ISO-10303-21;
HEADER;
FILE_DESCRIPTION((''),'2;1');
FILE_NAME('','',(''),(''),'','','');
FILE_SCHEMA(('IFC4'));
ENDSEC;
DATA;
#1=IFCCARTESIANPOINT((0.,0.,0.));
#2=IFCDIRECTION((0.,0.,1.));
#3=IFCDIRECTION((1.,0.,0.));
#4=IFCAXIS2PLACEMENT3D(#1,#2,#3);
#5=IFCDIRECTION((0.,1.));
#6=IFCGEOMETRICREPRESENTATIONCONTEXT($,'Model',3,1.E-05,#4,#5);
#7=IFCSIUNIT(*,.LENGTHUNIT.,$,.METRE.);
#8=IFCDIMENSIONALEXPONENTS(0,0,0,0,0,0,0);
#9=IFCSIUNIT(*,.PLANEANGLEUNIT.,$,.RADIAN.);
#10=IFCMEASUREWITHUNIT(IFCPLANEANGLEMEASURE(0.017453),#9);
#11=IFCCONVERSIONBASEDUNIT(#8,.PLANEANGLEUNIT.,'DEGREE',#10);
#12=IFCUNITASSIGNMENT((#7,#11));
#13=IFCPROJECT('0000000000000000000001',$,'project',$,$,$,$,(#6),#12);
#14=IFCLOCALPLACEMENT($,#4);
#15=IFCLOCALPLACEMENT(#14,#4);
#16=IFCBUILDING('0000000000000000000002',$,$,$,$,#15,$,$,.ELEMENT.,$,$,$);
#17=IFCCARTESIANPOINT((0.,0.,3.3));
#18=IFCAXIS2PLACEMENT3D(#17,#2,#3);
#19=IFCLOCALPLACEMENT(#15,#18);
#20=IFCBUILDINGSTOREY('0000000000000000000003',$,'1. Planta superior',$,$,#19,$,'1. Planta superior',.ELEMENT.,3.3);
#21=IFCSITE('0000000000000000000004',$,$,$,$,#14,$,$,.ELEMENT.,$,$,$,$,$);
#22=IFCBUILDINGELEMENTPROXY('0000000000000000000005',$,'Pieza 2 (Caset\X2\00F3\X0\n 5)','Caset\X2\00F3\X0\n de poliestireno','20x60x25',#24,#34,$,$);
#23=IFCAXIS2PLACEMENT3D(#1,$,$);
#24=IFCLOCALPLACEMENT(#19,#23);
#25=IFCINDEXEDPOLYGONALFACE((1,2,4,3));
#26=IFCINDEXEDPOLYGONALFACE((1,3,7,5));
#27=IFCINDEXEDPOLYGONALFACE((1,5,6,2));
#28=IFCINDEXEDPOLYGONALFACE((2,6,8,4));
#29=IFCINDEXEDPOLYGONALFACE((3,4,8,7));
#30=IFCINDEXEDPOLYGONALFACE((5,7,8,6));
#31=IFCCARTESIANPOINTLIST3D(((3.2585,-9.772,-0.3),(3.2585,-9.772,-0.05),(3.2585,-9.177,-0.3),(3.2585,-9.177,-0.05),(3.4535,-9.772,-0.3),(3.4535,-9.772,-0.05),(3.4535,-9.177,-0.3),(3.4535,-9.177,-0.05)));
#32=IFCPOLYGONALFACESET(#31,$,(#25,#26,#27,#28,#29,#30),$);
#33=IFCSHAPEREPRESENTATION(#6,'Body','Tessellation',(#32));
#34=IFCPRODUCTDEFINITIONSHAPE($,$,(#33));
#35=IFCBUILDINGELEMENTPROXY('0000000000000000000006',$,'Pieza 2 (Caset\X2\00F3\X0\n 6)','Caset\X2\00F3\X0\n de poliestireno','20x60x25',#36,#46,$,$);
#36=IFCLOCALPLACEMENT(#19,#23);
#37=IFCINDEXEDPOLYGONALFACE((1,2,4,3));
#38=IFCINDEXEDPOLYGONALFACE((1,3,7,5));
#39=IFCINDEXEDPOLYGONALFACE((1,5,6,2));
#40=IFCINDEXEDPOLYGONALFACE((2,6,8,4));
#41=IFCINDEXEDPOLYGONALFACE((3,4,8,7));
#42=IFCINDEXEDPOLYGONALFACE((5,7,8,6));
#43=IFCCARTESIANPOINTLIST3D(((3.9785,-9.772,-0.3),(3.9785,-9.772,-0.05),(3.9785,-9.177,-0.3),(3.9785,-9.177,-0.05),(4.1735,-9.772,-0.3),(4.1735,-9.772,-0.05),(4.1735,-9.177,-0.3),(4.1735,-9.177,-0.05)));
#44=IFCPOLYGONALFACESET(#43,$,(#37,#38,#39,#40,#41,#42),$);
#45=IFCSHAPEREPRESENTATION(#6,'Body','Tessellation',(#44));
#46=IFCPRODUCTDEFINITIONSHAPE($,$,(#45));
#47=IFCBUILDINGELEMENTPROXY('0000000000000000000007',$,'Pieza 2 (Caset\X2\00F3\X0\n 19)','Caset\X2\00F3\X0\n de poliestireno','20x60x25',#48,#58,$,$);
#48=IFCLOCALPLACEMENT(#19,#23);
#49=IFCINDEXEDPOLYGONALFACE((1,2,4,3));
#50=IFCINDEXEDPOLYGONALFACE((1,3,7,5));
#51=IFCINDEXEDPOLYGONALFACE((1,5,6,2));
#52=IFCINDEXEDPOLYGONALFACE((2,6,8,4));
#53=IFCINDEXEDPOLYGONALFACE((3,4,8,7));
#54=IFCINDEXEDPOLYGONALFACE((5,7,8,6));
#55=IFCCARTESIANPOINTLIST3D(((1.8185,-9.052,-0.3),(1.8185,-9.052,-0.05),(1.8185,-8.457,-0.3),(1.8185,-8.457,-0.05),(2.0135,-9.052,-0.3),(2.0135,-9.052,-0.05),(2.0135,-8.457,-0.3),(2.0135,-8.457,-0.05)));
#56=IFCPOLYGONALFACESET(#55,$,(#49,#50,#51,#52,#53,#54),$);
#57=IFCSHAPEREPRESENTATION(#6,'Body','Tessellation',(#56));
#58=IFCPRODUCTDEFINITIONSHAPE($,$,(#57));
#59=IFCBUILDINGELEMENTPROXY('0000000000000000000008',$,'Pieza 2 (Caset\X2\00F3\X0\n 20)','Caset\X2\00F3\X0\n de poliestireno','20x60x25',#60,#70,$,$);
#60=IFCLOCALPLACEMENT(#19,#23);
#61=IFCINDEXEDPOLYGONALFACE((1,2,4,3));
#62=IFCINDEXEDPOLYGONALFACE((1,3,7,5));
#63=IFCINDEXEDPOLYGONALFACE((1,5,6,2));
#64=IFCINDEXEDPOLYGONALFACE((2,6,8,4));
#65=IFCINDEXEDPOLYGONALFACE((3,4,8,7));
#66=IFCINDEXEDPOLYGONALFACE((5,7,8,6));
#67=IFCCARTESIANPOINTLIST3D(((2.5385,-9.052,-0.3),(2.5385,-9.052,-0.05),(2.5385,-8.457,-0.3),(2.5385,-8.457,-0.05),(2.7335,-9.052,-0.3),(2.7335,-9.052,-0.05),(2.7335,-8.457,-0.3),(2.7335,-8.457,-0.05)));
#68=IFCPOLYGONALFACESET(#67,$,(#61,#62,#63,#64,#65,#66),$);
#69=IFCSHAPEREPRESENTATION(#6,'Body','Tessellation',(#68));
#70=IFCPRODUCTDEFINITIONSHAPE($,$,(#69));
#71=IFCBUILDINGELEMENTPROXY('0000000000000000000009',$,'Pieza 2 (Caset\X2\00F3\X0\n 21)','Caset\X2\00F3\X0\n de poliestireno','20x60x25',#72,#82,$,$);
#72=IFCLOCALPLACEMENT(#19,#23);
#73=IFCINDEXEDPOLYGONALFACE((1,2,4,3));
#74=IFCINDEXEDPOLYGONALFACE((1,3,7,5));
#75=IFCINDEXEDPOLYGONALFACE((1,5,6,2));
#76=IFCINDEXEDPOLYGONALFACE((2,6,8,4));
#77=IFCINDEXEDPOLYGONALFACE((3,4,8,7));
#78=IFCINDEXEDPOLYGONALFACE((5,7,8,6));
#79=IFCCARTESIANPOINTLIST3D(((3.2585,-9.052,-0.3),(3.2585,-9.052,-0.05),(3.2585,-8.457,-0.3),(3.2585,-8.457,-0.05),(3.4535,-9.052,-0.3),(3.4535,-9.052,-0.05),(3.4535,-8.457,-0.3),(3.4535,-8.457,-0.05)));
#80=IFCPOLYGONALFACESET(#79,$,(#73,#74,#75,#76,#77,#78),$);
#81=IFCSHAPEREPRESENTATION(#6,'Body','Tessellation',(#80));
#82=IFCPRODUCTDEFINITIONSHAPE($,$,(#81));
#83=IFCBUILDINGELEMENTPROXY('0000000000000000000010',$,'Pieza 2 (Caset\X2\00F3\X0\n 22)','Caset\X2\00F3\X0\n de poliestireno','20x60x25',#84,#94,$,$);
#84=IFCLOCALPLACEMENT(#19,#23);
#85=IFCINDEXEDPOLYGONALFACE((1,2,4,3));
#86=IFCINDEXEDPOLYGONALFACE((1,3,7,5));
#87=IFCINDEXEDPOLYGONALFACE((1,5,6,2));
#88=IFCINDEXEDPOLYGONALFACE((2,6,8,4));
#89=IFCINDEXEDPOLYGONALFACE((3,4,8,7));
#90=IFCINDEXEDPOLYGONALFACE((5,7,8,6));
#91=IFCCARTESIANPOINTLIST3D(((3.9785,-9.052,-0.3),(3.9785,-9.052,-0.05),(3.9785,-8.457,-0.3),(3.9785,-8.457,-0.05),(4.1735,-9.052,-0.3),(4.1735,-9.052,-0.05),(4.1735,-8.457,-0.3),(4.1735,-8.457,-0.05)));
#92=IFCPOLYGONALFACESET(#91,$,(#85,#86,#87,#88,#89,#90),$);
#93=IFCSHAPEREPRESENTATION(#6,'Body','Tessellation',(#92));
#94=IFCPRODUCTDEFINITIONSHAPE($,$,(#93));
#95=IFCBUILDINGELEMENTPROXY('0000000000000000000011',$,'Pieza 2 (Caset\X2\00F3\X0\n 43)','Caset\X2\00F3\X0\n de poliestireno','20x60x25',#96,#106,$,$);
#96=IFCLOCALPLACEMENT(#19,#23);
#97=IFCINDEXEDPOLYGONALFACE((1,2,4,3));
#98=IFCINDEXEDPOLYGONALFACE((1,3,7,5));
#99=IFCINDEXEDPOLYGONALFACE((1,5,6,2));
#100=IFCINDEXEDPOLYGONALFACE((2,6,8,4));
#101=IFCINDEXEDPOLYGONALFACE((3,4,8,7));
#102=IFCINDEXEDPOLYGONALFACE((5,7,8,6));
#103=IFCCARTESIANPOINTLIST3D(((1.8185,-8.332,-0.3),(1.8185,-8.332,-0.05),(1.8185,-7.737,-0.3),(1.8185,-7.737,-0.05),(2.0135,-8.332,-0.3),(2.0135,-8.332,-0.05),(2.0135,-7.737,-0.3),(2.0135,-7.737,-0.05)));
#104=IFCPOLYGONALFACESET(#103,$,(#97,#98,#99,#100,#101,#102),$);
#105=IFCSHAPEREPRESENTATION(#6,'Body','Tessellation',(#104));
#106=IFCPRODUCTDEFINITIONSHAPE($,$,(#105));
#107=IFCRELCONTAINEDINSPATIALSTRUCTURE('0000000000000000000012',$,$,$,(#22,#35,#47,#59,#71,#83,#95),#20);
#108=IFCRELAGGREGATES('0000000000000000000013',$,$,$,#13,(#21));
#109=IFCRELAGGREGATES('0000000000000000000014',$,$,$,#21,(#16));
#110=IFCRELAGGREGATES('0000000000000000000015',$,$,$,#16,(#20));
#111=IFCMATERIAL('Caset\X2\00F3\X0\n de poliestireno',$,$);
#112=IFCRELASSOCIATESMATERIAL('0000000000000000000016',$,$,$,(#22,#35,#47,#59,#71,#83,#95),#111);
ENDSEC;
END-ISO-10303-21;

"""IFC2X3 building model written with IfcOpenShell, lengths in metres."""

from ifc_helpers import new_model, entity, si_unit, converted_unit, direction, frame, origin_with_axes, origin_2d_with_axis, place, context, project, spatial, rectangle, extrude, source, transform, mapped, material, element, save


model = new_model("IFC2X3")

# Units and contexts
model_context = context("Model", 3, precision=1e-05, world=origin_with_axes(), true_north=direction((0.0, 1.0)))
ifc_project = project(units=[si_unit("LENGTHUNIT", "METRE"), converted_unit("PLANEANGLEUNIT", "DEGREE", entity("IfcPlaneAngleMeasure", 0.017453), si_unit("PLANEANGLEUNIT", "RADIAN"), dimensions=[0, 0, 0, 0, 0, 0, 0])], contexts=[model_context])

# Site, building, storey
site_placement = place(None, origin_with_axes())
site = spatial("IfcSite", under=ifc_project, at=site_placement, CompositionType="ELEMENT")
building_placement = place(site_placement, origin_with_axes())
building = spatial("IfcBuilding", under=site, at=building_placement, CompositionType="ELEMENT")
storey_placement = place(building_placement, frame((0.0, 0.0, 3.3), z_axis=(0.0, 0.0, 1.0), x_axis=(1.0, 0.0, 0.0)))
storey = spatial("IfcBuildingStorey", under=building, at=storey_placement, Name="1. Planta superior", LongName="1. Planta superior", CompositionType="ELEMENT", Elevation=3.3)

# Building element proxies
ifc_material = material(Name="Casetón de poliestireno")
shared_shape = source(origin_with_axes(), model_context, "Body", "SweptSolid", [
    extrude(rectangle(XDim=0.195, YDim=0.25, at=origin_2d_with_axis()), origin_with_axes(), (0.0, 0.0, 1.0), 0.595),
])
placement_1 = place(storey_placement, frame((3.356, -9.772, -0.175), z_axis=(0.0, 1.0, 0.0), x_axis=(-1.0, 0.0, 0.0)))
for number, where, z_axis, x_axis, name in (
    (1, (0.0, 0.0, 0.0), (0.0, 0.0, 1.0), (1.0, 0.0, 0.0), "Pieza 2 (Casetón 5)"),
):
    element("IfcBuildingElementProxy", number, at=place(placement_1, frame(where, z_axis=z_axis, x_axis=x_axis)), inside=storey, material=ifc_material, Name=name, Description="Casetón de poliestireno", ObjectType="20x60x25", context=model_context, shape_type="MappedRepresentation", body=[
        mapped(shared_shape, transform((0.0, 0.0, 0.0), x_axis=(1.0, 0.0, 0.0), y_axis=(0.0, 1.0, 0.0), z_axis=(0.0, 0.0, 1.0))),
    ])
placement_2 = place(storey_placement, frame((4.076, -9.772, -0.175), z_axis=(0.0, 1.0, 0.0), x_axis=(-1.0, 0.0, 0.0)))
for number, where, z_axis, x_axis, name in (
    (2, (0.0, 0.0, 0.0), (0.0, 0.0, 1.0), (1.0, 0.0, 0.0), "Pieza 2 (Casetón 6)"),
):
    element("IfcBuildingElementProxy", number, at=place(placement_2, frame(where, z_axis=z_axis, x_axis=x_axis)), inside=storey, material=ifc_material, Name=name, Description="Casetón de poliestireno", ObjectType="20x60x25", context=model_context, shape_type="MappedRepresentation", body=[
        mapped(shared_shape, transform((0.0, 0.0, 0.0), x_axis=(1.0, 0.0, 0.0), y_axis=(0.0, 1.0, 0.0), z_axis=(0.0, 0.0, 1.0))),
    ])
placement_3 = place(storey_placement, frame((1.916, -9.052, -0.175), z_axis=(0.0, 1.0, 0.0), x_axis=(-1.0, 0.0, 0.0)))
for number, where, z_axis, x_axis, name in (
    (3, (0.0, 0.0, 0.0), (0.0, 0.0, 1.0), (1.0, 0.0, 0.0), "Pieza 2 (Casetón 19)"),
):
    element("IfcBuildingElementProxy", number, at=place(placement_3, frame(where, z_axis=z_axis, x_axis=x_axis)), inside=storey, material=ifc_material, Name=name, Description="Casetón de poliestireno", ObjectType="20x60x25", context=model_context, shape_type="MappedRepresentation", body=[
        mapped(shared_shape, transform((0.0, 0.0, 0.0), x_axis=(1.0, 0.0, 0.0), y_axis=(0.0, 1.0, 0.0), z_axis=(0.0, 0.0, 1.0))),
    ])
placement_4 = place(storey_placement, frame((2.636, -9.052, -0.175), z_axis=(0.0, 1.0, 0.0), x_axis=(-1.0, 0.0, 0.0)))
for number, where, z_axis, x_axis, name in (
    (4, (0.0, 0.0, 0.0), (0.0, 0.0, 1.0), (1.0, 0.0, 0.0), "Pieza 2 (Casetón 20)"),
):
    element("IfcBuildingElementProxy", number, at=place(placement_4, frame(where, z_axis=z_axis, x_axis=x_axis)), inside=storey, material=ifc_material, Name=name, Description="Casetón de poliestireno", ObjectType="20x60x25", context=model_context, shape_type="MappedRepresentation", body=[
        mapped(shared_shape, transform((0.0, 0.0, 0.0), x_axis=(1.0, 0.0, 0.0), y_axis=(0.0, 1.0, 0.0), z_axis=(0.0, 0.0, 1.0))),
    ])
placement_5 = place(storey_placement, frame((3.356, -9.052, -0.175), z_axis=(0.0, 1.0, 0.0), x_axis=(-1.0, 0.0, 0.0)))
for number, where, z_axis, x_axis, name in (
    (5, (0.0, 0.0, 0.0), (0.0, 0.0, 1.0), (1.0, 0.0, 0.0), "Pieza 2 (Casetón 21)"),
):
    element("IfcBuildingElementProxy", number, at=place(placement_5, frame(where, z_axis=z_axis, x_axis=x_axis)), inside=storey, material=ifc_material, Name=name, Description="Casetón de poliestireno", ObjectType="20x60x25", context=model_context, shape_type="MappedRepresentation", body=[
        mapped(shared_shape, transform((0.0, 0.0, 0.0), x_axis=(1.0, 0.0, 0.0), y_axis=(0.0, 1.0, 0.0), z_axis=(0.0, 0.0, 1.0))),
    ])
placement_6 = place(storey_placement, frame((4.076, -9.052, -0.175), z_axis=(0.0, 1.0, 0.0), x_axis=(-1.0, 0.0, 0.0)))
for number, where, z_axis, x_axis, name in (
    (6, (0.0, 0.0, 0.0), (0.0, 0.0, 1.0), (1.0, 0.0, 0.0), "Pieza 2 (Casetón 22)"),
):
    element("IfcBuildingElementProxy", number, at=place(placement_6, frame(where, z_axis=z_axis, x_axis=x_axis)), inside=storey, material=ifc_material, Name=name, Description="Casetón de poliestireno", ObjectType="20x60x25", context=model_context, shape_type="MappedRepresentation", body=[
        mapped(shared_shape, transform((0.0, 0.0, 0.0), x_axis=(1.0, 0.0, 0.0), y_axis=(0.0, 1.0, 0.0), z_axis=(0.0, 0.0, 1.0))),
    ])
placement_7 = place(storey_placement, frame((1.916, -8.332, -0.175), z_axis=(0.0, 1.0, 0.0), x_axis=(-1.0, 0.0, 0.0)))
for number, where, z_axis, x_axis, name in (
    (7, (0.0, 0.0, 0.0), (0.0, 0.0, 1.0), (1.0, 0.0, 0.0), "Pieza 2 (Casetón 43)"),
):
    element("IfcBuildingElementProxy", number, at=place(placement_7, frame(where, z_axis=z_axis, x_axis=x_axis)), inside=storey, material=ifc_material, Name=name, Description="Casetón de poliestireno", ObjectType="20x60x25", context=model_context, shape_type="MappedRepresentation", body=[
        mapped(shared_shape, transform((0.0, 0.0, 0.0), x_axis=(1.0, 0.0, 0.0), y_axis=(0.0, 1.0, 0.0), z_axis=(0.0, 0.0, 1.0))),
    ])

save(model, "model.ifc")
